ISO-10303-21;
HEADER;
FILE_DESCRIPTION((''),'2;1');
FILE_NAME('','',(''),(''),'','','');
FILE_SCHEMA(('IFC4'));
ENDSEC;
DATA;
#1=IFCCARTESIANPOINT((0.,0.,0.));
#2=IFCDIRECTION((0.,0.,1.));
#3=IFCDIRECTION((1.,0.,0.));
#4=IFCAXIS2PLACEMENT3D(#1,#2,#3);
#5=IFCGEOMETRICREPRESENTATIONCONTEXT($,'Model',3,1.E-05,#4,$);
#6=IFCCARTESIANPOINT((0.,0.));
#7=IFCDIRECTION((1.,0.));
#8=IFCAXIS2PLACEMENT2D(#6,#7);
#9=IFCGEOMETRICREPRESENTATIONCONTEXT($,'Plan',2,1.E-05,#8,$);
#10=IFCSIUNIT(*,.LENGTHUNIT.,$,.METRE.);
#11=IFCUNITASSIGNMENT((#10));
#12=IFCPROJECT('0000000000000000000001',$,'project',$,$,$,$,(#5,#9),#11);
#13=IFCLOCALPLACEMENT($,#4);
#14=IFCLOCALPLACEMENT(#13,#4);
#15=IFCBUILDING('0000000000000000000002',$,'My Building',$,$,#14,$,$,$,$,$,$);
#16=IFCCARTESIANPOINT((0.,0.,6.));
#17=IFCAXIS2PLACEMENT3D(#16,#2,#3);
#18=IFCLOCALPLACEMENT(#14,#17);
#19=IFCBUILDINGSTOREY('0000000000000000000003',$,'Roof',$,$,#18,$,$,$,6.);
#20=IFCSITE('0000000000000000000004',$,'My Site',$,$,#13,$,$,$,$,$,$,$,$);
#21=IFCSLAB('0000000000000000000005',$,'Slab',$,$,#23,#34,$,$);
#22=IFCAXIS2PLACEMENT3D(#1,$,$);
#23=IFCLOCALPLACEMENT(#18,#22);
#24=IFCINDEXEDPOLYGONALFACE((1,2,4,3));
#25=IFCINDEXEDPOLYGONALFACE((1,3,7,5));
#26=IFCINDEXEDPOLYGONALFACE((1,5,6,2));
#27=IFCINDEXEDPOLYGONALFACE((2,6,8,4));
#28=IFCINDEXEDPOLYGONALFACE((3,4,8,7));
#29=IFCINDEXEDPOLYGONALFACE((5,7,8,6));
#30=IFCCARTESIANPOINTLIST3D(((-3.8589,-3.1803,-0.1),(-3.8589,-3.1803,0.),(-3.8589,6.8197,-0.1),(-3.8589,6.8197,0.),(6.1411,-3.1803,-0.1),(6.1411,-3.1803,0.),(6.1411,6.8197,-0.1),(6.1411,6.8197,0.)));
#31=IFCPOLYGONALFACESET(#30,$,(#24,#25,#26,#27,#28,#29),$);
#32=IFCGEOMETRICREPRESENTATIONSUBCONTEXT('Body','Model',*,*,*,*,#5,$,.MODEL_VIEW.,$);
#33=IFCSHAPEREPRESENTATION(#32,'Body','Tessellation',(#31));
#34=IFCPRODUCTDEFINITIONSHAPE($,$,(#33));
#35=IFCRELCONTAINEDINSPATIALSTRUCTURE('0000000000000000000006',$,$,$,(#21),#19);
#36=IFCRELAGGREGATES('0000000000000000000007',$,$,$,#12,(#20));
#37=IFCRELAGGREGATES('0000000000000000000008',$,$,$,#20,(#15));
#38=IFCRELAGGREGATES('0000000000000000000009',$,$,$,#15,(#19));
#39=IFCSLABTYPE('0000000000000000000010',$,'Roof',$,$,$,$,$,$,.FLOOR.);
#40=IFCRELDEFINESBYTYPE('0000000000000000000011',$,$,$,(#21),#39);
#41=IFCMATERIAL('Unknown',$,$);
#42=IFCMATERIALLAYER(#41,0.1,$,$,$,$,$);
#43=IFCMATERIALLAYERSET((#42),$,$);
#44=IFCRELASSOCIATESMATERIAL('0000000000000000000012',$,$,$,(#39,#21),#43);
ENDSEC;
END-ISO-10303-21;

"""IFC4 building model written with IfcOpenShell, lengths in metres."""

from ifc_helpers import new_model, si_unit, frame, origin_with_axes, origin_2d_with_axis, place, context, subcontext, project, spatial, indexed_curve, outline, extrude, material, layer, layer_set, layer_usage, type_object, element, save


model = new_model("IFC4")

# Units and contexts
model_context = context("Model", 3, precision=1e-05, world=origin_with_axes())
plan_context = context("Plan", 2, precision=1e-05, world=origin_2d_with_axis())
body_context = subcontext(model_context, "Body", "Model", "MODEL_VIEW")
ifc_project = project(units=[si_unit("LENGTHUNIT", "METRE")], contexts=[model_context, plan_context])

# Site, building, storey
site_placement = place(None, origin_with_axes())
site = spatial("IfcSite", under=ifc_project, at=site_placement, Name="My Site")
building_placement = place(site_placement, origin_with_axes())
building = spatial("IfcBuilding", under=site, at=building_placement, Name="My Building")
storey_placement = place(building_placement, frame((0.0, 0.0, 6.0), z_axis=(0.0, 0.0, 1.0), x_axis=(1.0, 0.0, 0.0)))
storey = spatial("IfcBuildingStorey", under=building, at=storey_placement, Name="Roof", Elevation=6.0)

# Slab
ifc_material = material(Name="Unknown")
ifc_layer = layer(ifc_material, 0.1)
ifc_layer_set = layer_set([ifc_layer])
ifc_layer_usage = layer_usage(ifc_layer_set, "AXIS3", "POSITIVE", -0.1)
slab_type = type_object("IfcSlabType", Name="Roof", PredefinedType="FLOOR", material=ifc_layer_set)
slab_placement = place(storey_placement, frame((-3.8589, 6.8197, 0.0), z_axis=(0.0, 0.0, 1.0), x_axis=(1.0, 0.0, 0.0)))
element("IfcSlab", 1, at=slab_placement, inside=storey, type_object=slab_type, material=ifc_layer_usage, Name="Slab", context=body_context, shape_type="SweptSolid", body=[
    extrude(outline(indexed_curve([(0.0, 0.0), (0.0, -10.0), (10.0, -10.0), (10.0, 0.0), (0.0, 0.0)])), frame((0.0, 0.0, -0.1), z_axis=(0.0, 0.0, 1.0), x_axis=(1.0, 0.0, 0.0)), (0.0, 0.0, 1.0), 0.1),
])

save(model, "model.ifc")
